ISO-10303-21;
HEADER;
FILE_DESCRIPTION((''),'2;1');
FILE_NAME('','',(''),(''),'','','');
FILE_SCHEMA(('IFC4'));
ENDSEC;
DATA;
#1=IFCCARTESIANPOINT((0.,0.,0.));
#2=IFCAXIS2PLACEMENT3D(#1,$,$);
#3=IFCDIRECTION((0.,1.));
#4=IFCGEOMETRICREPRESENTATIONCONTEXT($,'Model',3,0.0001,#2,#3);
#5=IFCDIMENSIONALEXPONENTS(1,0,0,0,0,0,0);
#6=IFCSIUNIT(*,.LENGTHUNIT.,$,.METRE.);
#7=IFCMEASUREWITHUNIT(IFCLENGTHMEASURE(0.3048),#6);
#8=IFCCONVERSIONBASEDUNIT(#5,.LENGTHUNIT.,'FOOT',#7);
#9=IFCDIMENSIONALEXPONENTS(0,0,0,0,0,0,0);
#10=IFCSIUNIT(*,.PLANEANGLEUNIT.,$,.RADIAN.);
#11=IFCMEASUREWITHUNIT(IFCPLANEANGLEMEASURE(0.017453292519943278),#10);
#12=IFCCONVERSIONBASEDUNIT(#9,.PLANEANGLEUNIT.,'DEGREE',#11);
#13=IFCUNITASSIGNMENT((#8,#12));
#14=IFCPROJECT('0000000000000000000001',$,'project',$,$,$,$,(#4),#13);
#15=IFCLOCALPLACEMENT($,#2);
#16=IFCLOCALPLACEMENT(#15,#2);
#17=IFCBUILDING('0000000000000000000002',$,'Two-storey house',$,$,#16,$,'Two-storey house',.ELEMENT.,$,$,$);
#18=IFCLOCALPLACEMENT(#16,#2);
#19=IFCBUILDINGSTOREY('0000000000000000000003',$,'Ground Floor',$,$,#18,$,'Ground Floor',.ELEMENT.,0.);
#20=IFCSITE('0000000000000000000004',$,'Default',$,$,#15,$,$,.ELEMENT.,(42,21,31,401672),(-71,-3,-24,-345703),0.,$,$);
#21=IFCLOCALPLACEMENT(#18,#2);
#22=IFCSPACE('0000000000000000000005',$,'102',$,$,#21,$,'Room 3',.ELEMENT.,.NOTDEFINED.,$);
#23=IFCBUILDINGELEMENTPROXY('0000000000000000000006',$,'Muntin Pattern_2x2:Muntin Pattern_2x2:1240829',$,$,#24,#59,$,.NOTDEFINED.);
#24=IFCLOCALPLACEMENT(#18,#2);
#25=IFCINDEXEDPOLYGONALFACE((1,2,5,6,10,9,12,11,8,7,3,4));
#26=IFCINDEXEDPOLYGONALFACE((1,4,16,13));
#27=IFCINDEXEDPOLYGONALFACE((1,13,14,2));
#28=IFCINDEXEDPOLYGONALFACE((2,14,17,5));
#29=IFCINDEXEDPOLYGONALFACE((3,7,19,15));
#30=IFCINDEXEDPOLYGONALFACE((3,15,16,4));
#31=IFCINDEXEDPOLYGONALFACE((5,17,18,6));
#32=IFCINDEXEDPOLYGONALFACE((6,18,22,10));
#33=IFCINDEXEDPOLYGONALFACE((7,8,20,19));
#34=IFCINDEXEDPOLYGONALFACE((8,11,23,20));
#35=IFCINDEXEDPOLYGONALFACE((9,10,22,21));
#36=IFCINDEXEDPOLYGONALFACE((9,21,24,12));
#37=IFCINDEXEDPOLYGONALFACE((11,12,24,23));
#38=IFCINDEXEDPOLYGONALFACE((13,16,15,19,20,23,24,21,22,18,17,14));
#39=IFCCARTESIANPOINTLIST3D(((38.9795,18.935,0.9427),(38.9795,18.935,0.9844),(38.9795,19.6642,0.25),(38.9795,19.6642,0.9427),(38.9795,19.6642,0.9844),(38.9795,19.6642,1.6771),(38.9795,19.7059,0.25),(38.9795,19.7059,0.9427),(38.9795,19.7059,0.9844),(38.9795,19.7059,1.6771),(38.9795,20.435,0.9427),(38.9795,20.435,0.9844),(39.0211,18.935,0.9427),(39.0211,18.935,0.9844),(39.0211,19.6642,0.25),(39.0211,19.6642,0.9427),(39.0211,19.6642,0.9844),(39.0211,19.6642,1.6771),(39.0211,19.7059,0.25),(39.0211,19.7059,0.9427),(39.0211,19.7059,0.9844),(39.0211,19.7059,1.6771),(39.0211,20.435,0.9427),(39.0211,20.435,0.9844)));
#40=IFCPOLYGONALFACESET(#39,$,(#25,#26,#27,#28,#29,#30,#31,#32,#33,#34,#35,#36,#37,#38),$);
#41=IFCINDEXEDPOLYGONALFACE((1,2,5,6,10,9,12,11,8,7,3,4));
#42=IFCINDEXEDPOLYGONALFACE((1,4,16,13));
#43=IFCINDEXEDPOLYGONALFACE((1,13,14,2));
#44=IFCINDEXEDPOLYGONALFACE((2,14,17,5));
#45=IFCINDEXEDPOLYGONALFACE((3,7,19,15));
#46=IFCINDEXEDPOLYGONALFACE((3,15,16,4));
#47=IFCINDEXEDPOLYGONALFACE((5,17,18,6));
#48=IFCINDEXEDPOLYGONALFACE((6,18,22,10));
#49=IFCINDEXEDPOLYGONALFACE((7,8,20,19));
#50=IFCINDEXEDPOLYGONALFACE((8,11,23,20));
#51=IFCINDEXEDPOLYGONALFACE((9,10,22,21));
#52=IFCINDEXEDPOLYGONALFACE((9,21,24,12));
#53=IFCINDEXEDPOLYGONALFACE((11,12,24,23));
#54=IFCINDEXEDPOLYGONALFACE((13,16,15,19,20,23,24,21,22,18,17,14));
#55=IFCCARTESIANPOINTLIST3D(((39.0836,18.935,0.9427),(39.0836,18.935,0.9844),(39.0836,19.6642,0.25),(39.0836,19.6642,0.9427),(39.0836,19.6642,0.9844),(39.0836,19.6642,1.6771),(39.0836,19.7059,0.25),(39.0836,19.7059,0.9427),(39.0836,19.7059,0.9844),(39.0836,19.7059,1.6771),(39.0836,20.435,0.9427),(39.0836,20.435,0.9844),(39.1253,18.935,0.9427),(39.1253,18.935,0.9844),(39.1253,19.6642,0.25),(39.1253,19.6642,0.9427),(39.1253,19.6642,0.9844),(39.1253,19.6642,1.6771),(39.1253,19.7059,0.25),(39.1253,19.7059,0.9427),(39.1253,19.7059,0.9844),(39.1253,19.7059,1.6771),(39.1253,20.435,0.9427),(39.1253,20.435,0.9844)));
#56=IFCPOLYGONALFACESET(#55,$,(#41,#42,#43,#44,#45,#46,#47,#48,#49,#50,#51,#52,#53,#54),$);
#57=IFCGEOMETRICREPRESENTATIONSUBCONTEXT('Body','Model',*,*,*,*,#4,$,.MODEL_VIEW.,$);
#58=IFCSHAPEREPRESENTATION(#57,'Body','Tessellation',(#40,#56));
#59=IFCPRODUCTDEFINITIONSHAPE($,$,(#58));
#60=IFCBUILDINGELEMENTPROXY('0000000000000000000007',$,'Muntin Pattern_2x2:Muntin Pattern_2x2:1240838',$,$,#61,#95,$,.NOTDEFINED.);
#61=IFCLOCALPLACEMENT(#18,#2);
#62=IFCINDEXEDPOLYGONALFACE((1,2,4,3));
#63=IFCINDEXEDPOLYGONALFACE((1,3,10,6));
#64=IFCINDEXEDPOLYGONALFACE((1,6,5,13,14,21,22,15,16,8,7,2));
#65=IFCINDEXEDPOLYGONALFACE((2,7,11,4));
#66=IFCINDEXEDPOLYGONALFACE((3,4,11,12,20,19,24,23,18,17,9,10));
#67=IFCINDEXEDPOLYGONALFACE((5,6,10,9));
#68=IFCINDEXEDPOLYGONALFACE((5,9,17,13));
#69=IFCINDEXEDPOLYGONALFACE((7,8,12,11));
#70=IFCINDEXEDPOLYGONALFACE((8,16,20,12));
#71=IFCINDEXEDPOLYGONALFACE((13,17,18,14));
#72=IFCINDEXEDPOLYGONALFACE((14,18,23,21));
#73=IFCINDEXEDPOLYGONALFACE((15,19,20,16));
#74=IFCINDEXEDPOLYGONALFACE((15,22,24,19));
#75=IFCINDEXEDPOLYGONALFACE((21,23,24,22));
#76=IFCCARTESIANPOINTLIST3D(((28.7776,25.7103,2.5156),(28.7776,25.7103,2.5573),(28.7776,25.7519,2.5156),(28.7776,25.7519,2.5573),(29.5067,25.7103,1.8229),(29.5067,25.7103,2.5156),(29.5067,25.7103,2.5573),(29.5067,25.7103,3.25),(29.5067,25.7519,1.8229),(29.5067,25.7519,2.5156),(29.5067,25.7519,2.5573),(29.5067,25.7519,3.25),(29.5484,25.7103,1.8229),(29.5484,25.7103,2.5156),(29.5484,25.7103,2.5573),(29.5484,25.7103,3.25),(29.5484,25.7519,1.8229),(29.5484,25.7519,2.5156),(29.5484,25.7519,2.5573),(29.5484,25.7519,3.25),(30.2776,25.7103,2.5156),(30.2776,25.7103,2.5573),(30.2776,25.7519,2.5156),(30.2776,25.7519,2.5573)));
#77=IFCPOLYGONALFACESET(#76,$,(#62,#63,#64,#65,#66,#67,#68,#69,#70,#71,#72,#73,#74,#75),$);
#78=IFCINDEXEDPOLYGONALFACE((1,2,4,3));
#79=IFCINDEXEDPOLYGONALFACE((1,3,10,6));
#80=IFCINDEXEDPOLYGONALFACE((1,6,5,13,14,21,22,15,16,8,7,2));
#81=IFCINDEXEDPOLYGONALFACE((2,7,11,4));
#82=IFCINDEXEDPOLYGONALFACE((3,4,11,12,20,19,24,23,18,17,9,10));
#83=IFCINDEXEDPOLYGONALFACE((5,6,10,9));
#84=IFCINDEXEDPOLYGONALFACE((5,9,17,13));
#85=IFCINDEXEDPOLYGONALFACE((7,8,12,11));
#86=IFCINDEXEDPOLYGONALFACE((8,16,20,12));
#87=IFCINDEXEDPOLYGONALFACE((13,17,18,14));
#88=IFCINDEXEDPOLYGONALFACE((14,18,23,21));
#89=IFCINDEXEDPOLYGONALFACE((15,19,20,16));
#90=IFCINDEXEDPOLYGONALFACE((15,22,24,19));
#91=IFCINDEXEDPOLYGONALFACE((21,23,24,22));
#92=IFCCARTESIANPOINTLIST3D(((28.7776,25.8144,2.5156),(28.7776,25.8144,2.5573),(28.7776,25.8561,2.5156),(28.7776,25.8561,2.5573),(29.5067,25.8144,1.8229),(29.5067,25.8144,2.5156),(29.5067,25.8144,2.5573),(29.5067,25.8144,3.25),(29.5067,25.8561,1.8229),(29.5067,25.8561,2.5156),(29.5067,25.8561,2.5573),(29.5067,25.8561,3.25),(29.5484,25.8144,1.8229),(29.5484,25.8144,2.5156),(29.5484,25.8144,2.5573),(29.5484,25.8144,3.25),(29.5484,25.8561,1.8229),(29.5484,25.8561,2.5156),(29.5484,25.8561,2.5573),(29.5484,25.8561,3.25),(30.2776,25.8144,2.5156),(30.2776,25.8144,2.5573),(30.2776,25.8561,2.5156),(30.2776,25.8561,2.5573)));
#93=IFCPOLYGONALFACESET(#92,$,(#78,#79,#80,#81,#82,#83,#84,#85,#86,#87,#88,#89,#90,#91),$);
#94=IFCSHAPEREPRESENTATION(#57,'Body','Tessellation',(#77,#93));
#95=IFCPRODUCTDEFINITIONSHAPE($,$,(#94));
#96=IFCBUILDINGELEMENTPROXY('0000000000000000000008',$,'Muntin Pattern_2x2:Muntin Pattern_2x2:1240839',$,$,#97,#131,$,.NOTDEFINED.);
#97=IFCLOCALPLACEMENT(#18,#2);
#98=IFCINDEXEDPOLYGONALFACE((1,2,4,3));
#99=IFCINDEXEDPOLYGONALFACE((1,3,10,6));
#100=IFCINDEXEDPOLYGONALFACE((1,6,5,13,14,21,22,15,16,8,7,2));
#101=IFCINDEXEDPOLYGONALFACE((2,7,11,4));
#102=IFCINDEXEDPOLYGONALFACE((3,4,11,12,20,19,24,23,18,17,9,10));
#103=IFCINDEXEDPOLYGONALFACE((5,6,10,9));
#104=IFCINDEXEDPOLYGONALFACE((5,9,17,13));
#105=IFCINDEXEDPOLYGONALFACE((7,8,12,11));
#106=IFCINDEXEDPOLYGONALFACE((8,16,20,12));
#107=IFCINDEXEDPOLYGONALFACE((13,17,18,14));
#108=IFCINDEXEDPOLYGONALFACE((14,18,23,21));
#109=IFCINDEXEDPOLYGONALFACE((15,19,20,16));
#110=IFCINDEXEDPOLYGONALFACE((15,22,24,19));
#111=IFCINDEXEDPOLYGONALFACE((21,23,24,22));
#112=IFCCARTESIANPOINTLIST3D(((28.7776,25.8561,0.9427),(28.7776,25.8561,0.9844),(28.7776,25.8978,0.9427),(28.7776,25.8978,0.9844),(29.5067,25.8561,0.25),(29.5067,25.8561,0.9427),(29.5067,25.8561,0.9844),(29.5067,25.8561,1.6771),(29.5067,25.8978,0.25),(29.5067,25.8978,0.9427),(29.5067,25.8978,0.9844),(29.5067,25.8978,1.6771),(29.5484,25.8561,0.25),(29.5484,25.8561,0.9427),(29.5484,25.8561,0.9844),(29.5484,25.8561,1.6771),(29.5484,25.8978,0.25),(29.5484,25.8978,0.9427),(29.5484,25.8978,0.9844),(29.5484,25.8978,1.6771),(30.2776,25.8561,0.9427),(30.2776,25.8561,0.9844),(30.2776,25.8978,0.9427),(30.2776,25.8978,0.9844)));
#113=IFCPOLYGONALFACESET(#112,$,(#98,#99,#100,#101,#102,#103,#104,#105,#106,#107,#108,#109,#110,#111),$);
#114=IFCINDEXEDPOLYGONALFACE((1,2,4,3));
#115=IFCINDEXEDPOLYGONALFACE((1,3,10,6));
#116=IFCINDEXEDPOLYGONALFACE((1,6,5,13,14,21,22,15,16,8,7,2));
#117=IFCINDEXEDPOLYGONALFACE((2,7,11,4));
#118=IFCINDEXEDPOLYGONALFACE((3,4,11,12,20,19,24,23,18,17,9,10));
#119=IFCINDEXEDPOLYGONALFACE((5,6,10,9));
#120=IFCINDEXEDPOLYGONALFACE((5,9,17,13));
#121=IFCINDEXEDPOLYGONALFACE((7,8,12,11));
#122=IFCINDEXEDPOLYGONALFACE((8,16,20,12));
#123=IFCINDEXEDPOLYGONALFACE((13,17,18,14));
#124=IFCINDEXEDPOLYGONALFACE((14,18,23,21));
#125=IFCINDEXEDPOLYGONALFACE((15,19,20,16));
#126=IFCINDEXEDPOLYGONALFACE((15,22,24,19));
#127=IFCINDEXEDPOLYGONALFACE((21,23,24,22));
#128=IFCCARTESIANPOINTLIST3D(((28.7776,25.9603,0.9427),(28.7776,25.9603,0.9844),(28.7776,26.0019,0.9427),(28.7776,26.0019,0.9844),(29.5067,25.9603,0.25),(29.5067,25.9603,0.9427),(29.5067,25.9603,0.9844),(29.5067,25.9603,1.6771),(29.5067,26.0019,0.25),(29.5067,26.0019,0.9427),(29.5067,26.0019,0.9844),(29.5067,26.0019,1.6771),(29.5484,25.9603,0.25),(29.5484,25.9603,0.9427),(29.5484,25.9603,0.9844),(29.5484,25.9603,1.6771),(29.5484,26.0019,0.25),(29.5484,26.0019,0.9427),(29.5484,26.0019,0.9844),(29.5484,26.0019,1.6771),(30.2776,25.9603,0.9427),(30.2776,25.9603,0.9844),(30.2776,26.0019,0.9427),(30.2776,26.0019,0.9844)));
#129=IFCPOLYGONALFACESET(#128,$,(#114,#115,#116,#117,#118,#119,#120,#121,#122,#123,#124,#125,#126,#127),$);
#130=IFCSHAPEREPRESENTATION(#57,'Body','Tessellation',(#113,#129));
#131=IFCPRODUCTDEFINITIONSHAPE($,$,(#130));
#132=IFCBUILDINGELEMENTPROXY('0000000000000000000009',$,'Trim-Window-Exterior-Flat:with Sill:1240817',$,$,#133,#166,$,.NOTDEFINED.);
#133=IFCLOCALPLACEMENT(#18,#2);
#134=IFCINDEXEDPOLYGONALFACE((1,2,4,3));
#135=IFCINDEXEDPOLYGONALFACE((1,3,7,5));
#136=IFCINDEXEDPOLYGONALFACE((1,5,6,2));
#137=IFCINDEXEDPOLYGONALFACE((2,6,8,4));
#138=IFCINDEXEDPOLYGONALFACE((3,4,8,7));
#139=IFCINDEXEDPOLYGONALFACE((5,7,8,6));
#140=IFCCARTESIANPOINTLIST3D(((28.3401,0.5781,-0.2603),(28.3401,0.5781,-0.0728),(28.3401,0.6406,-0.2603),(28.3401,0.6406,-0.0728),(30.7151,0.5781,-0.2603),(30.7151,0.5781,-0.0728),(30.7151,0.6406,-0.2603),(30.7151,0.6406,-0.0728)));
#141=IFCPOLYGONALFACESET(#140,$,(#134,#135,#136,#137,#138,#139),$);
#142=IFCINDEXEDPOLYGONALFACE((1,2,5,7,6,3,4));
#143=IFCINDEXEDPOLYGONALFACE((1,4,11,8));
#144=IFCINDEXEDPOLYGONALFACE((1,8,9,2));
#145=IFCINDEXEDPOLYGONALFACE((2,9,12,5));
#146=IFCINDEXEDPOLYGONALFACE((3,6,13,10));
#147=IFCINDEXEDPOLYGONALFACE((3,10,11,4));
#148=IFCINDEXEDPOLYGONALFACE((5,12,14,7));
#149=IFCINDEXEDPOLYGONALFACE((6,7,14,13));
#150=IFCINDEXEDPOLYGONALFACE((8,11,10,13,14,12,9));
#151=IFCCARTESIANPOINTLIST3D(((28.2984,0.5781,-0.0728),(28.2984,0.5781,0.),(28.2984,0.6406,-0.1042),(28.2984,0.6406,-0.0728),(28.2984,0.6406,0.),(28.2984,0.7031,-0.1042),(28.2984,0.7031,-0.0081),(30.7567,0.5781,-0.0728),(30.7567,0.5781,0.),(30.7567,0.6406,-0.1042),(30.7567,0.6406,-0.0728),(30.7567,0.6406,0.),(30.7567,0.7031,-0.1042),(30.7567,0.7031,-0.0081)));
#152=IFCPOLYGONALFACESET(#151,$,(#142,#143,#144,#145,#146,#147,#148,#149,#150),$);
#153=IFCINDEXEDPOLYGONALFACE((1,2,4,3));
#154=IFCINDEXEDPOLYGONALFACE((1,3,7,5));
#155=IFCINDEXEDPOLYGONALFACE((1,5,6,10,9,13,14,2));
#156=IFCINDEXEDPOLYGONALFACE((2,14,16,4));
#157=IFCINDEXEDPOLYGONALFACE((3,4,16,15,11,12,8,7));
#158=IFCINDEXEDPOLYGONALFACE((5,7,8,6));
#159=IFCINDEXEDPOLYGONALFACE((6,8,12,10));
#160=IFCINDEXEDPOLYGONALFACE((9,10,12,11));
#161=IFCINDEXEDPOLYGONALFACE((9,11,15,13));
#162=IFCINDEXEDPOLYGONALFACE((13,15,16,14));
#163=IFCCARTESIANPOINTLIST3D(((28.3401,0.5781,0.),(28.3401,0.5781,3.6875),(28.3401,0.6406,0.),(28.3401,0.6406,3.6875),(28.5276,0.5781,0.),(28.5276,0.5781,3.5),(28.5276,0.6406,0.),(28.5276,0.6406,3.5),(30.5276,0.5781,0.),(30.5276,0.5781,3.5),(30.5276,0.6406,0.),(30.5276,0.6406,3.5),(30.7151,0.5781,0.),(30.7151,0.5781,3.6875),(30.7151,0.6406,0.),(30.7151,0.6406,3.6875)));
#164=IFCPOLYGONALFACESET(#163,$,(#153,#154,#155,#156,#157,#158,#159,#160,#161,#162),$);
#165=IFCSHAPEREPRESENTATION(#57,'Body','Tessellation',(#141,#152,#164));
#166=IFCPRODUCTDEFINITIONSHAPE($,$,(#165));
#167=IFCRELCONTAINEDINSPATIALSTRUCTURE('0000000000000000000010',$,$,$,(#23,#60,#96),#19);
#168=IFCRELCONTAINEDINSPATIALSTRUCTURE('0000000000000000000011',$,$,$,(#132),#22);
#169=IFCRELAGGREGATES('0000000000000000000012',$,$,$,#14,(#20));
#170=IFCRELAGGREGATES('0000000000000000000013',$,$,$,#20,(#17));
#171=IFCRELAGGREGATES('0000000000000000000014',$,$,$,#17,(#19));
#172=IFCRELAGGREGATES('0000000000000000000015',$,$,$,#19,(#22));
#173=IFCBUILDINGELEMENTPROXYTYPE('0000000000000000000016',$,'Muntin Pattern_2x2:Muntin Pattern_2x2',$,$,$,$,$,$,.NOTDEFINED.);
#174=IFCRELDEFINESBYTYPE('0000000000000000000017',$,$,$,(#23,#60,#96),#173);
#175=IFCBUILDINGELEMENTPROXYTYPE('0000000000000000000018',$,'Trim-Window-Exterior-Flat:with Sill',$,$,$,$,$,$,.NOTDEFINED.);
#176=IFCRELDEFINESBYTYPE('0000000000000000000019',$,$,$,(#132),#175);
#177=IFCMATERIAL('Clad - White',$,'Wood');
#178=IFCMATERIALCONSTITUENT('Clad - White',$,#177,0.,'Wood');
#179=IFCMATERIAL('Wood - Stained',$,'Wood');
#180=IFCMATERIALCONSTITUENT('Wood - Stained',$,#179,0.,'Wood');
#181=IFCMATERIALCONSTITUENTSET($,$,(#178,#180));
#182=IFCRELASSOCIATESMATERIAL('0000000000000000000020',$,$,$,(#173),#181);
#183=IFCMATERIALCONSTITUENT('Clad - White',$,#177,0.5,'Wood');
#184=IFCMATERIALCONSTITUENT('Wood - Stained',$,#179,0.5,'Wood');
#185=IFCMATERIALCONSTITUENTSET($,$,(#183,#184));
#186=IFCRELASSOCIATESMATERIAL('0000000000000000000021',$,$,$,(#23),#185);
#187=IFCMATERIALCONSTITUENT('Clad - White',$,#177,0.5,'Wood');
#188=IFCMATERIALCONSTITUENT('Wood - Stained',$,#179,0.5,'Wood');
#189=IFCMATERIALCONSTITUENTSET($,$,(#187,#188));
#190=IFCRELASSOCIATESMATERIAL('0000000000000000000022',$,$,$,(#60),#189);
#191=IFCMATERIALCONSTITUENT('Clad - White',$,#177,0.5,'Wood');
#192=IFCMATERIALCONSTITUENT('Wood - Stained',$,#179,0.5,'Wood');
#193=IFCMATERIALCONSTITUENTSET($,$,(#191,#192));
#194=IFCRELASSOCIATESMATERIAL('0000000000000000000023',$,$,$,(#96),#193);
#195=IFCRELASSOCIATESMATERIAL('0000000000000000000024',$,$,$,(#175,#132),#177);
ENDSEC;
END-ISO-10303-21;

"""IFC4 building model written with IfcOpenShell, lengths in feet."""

from ifc_helpers import new_model, entity, si_unit, converted_unit, direction, frame, origin, place, context, subcontext, project, spatial, indexed_curve, outline, extrude, source, transform, mapped, material, constituent, constituent_set, type_object, type_shapes, element, save


model = new_model("IFC4")

# Units and contexts
model_context = context("Model", 3, precision=0.0001, world=origin(), true_north=direction((0.0, 1.0)))
body_context = subcontext(model_context, "Body", "Model", "MODEL_VIEW")
ifc_project = project(units=[converted_unit("LENGTHUNIT", "FOOT", entity("IfcLengthMeasure", 0.3048), si_unit("LENGTHUNIT", "METRE"), dimensions=[1, 0, 0, 0, 0, 0, 0]), converted_unit("PLANEANGLEUNIT", "DEGREE", entity("IfcPlaneAngleMeasure", 0.017453292519943278), si_unit("PLANEANGLEUNIT", "RADIAN"), dimensions=[0, 0, 0, 0, 0, 0, 0])], contexts=[model_context])

# Site, building, storey
site_placement = place(None, origin())
site = spatial("IfcSite", under=ifc_project, at=site_placement, Name="Default", CompositionType="ELEMENT", RefLatitude=(42, 21, 31, 401672), RefLongitude=(-71, -3, -24, -345703), RefElevation=0.0)
building_placement = place(site_placement, origin())
building = spatial("IfcBuilding", under=site, at=building_placement, Name="Two-storey house", LongName="Two-storey house", CompositionType="ELEMENT")
storey_placement = place(building_placement, origin())
storey = spatial("IfcBuildingStorey", under=building, at=storey_placement, Name="Ground Floor", LongName="Ground Floor", CompositionType="ELEMENT", Elevation=0.0)

# Shared definitions
ifc_material_1 = material(Name="Wood - Stained", Category="Wood")

# Building element proxies
ifc_material_2 = material(Name="Clad - White", Category="Wood")
ifc_constituent_1 = constituent(ifc_material_2, Name="Clad - White", Category="Wood", fraction=0.0)
ifc_constituent_2 = constituent(ifc_material_1, Name="Wood - Stained", Category="Wood", fraction=0.0)
ifc_constituent_set_1 = constituent_set(constituents=[ifc_constituent_1, ifc_constituent_2])
building_element_proxy_type_1 = type_object("IfcBuildingElementProxyType", Name="Muntin Pattern_2x2:Muntin Pattern_2x2", PredefinedType="NOTDEFINED", material=ifc_constituent_set_1)
shared_shape_1 = source(origin(), body_context, "Body", "SweptSolid", [
    extrude(outline(indexed_curve([(0.0208, -0.0208), (0.7135, -0.0208), (0.7135, 0.0208), (0.0208, 0.0208), (0.0208, 0.75), (-0.0208, 0.75), (-0.0208, 0.0208), (-0.7135, 0.0208), (-0.7135, -0.0208), (-0.0208, -0.0208), (-0.0208, -0.75), (0.0208, -0.75), (0.0208, -0.0208)], self_intersect=False)), frame((0.0, 0.0312, 0.7135), z_axis=(0.0, 1.0, 0.0), x_axis=(0.0, 0.0, 1.0)), (0.0, 0.0, 1.0), 0.0417),
    extrude(outline(indexed_curve([(0.0208, -0.0208), (0.7135, -0.0208), (0.7135, 0.0208), (0.0208, 0.0208), (0.0208, 0.75), (-0.0208, 0.75), (-0.0208, 0.0208), (-0.7135, 0.0208), (-0.7135, -0.0208), (-0.0208, -0.0208), (-0.0208, -0.75), (0.0208, -0.75), (0.0208, -0.0208)], self_intersect=False)), frame((0.0, -0.0729, 0.7135), z_axis=(0.0, 1.0, 0.0), x_axis=(0.0, 0.0, 1.0)), (0.0, 0.0, 1.0), 0.0417),
])
type_shapes(building_element_proxy_type_1, [shared_shape_1])
ifc_constituent_3 = constituent(ifc_material_2, Name="Clad - White", Category="Wood", fraction=0.5)
ifc_constituent_4 = constituent(ifc_material_1, Name="Wood - Stained", Category="Wood", fraction=0.5)
ifc_constituent_set_2 = constituent_set(constituents=[ifc_constituent_3, ifc_constituent_4])
proxy_1_placement = place(storey_placement, frame((39.0524, 19.685, 0.25), z_axis=(0.0, 0.0, 1.0), x_axis=(0.0, 1.0, 0.0)))
element("IfcBuildingElementProxy", 1, at=proxy_1_placement, inside=storey, type_object=building_element_proxy_type_1, material=ifc_constituent_set_2, Name="Muntin Pattern_2x2:Muntin Pattern_2x2:1240829", PredefinedType="NOTDEFINED", context=body_context, shape_type="MappedRepresentation", body=[
    mapped(shared_shape_1, transform((0.0, 0.0, 0.0), scale=1.0)),
])
ifc_constituent_5 = constituent(ifc_material_2, Name="Clad - White", Category="Wood", fraction=0.5)
ifc_constituent_6 = constituent(ifc_material_1, Name="Wood - Stained", Category="Wood", fraction=0.5)
ifc_constituent_set_3 = constituent_set(constituents=[ifc_constituent_5, ifc_constituent_6])
proxy_2_placement = place(storey_placement, frame((29.5276, 25.7832, 1.8229), z_axis=(0.0, 0.0, 1.0), x_axis=(-1.0, 0.0, 0.0)))
element("IfcBuildingElementProxy", 2, at=proxy_2_placement, inside=storey, type_object=building_element_proxy_type_1, material=ifc_constituent_set_3, Name="Muntin Pattern_2x2:Muntin Pattern_2x2:1240838", PredefinedType="NOTDEFINED", context=body_context, shape_type="MappedRepresentation", body=[
    mapped(shared_shape_1, transform((0.0, 0.0, 0.0), scale=1.0)),
])
ifc_constituent_7 = constituent(ifc_material_2, Name="Clad - White", Category="Wood", fraction=0.5)
ifc_constituent_8 = constituent(ifc_material_1, Name="Wood - Stained", Category="Wood", fraction=0.5)
ifc_constituent_set_4 = constituent_set(constituents=[ifc_constituent_7, ifc_constituent_8])
proxy_3_placement = place(storey_placement, frame((29.5276, 25.929, 0.25), z_axis=(0.0, 0.0, 1.0), x_axis=(-1.0, 0.0, 0.0)))
element("IfcBuildingElementProxy", 3, at=proxy_3_placement, inside=storey, type_object=building_element_proxy_type_1, material=ifc_constituent_set_4, Name="Muntin Pattern_2x2:Muntin Pattern_2x2:1240839", PredefinedType="NOTDEFINED", context=body_context, shape_type="MappedRepresentation", body=[
    mapped(shared_shape_1, transform((0.0, 0.0, 0.0), scale=1.0)),
])

# Shared definitions
space_1_placement = place(storey_placement, origin())
space_1 = spatial("IfcSpace", under=storey, at=space_1_placement, Name="102", LongName="Room 3", CompositionType="ELEMENT", PredefinedType="NOTDEFINED")

# Building element proxy
building_element_proxy_type_2 = type_object("IfcBuildingElementProxyType", Name="Trim-Window-Exterior-Flat:with Sill", PredefinedType="NOTDEFINED", material=ifc_material_2)
shared_shape_2 = source(origin(), body_context, "Body", "SweptSolid", [
    extrude(outline(indexed_curve([(-1.1875, -0.0938), (1.1875, -0.0938), (1.1875, 0.0938), (-1.1875, 0.0938), (-1.1875, -0.0938)], self_intersect=False)), frame((0.0, -3.6665, 0.0), z_axis=(0.0, 0.0, 1.0), x_axis=(-1.0, 0.0, 0.0)), (0.0, 0.0, 1.0), 0.0625),
    extrude(outline(indexed_curve([(-0.0625, -0.0525), (0.0, -0.0525), (0.0, -0.0211), (0.0625, -0.0211), (0.0625, 0.0517), (0.0, 0.0517), (-0.0625, 0.0436), (-0.0625, -0.0525)], self_intersect=False)), frame((-1.2292, -3.5517, 0.0625), z_axis=(1.0, 0.0, 0.0), x_axis=(0.0, 0.0, -1.0)), (0.0, 0.0, 1.0), 2.4583),
    extrude(outline(indexed_curve([(-1.8906, -1.1875), (1.7969, -1.1875), (1.7969, -1.0), (-1.7031, -1.0), (-1.7031, 1.0), (1.7969, 1.0), (1.7969, 1.1875), (-1.8906, 1.1875), (-1.8906, -1.1875)], self_intersect=False)), frame((0.0, -1.7031, 0.0), z_axis=(0.0, 0.0, 1.0), x_axis=(0.0, -1.0, 0.0)), (0.0, 0.0, 1.0), 0.0625),
])
type_shapes(building_element_proxy_type_2, [shared_shape_2])
for number, where, z_axis, x_axis, name in (
    (4, (29.5276, 0.5781, 3.5), (0.0, 1.0, 0.0), (-1.0, 0.0, 0.0), "Trim-Window-Exterior-Flat:with Sill:1240817"),
):
    element("IfcBuildingElementProxy", number, at=place(space_1_placement, frame(where, z_axis=z_axis, x_axis=x_axis)), inside=space_1, type_object=building_element_proxy_type_2, material=ifc_material_2, Name=name, PredefinedType="NOTDEFINED", context=body_context, shape_type="MappedRepresentation", body=[
        mapped(shared_shape_2, transform((0.0, 0.0, 0.0), scale=1.0)),
    ])

save(model, "model.ifc")
